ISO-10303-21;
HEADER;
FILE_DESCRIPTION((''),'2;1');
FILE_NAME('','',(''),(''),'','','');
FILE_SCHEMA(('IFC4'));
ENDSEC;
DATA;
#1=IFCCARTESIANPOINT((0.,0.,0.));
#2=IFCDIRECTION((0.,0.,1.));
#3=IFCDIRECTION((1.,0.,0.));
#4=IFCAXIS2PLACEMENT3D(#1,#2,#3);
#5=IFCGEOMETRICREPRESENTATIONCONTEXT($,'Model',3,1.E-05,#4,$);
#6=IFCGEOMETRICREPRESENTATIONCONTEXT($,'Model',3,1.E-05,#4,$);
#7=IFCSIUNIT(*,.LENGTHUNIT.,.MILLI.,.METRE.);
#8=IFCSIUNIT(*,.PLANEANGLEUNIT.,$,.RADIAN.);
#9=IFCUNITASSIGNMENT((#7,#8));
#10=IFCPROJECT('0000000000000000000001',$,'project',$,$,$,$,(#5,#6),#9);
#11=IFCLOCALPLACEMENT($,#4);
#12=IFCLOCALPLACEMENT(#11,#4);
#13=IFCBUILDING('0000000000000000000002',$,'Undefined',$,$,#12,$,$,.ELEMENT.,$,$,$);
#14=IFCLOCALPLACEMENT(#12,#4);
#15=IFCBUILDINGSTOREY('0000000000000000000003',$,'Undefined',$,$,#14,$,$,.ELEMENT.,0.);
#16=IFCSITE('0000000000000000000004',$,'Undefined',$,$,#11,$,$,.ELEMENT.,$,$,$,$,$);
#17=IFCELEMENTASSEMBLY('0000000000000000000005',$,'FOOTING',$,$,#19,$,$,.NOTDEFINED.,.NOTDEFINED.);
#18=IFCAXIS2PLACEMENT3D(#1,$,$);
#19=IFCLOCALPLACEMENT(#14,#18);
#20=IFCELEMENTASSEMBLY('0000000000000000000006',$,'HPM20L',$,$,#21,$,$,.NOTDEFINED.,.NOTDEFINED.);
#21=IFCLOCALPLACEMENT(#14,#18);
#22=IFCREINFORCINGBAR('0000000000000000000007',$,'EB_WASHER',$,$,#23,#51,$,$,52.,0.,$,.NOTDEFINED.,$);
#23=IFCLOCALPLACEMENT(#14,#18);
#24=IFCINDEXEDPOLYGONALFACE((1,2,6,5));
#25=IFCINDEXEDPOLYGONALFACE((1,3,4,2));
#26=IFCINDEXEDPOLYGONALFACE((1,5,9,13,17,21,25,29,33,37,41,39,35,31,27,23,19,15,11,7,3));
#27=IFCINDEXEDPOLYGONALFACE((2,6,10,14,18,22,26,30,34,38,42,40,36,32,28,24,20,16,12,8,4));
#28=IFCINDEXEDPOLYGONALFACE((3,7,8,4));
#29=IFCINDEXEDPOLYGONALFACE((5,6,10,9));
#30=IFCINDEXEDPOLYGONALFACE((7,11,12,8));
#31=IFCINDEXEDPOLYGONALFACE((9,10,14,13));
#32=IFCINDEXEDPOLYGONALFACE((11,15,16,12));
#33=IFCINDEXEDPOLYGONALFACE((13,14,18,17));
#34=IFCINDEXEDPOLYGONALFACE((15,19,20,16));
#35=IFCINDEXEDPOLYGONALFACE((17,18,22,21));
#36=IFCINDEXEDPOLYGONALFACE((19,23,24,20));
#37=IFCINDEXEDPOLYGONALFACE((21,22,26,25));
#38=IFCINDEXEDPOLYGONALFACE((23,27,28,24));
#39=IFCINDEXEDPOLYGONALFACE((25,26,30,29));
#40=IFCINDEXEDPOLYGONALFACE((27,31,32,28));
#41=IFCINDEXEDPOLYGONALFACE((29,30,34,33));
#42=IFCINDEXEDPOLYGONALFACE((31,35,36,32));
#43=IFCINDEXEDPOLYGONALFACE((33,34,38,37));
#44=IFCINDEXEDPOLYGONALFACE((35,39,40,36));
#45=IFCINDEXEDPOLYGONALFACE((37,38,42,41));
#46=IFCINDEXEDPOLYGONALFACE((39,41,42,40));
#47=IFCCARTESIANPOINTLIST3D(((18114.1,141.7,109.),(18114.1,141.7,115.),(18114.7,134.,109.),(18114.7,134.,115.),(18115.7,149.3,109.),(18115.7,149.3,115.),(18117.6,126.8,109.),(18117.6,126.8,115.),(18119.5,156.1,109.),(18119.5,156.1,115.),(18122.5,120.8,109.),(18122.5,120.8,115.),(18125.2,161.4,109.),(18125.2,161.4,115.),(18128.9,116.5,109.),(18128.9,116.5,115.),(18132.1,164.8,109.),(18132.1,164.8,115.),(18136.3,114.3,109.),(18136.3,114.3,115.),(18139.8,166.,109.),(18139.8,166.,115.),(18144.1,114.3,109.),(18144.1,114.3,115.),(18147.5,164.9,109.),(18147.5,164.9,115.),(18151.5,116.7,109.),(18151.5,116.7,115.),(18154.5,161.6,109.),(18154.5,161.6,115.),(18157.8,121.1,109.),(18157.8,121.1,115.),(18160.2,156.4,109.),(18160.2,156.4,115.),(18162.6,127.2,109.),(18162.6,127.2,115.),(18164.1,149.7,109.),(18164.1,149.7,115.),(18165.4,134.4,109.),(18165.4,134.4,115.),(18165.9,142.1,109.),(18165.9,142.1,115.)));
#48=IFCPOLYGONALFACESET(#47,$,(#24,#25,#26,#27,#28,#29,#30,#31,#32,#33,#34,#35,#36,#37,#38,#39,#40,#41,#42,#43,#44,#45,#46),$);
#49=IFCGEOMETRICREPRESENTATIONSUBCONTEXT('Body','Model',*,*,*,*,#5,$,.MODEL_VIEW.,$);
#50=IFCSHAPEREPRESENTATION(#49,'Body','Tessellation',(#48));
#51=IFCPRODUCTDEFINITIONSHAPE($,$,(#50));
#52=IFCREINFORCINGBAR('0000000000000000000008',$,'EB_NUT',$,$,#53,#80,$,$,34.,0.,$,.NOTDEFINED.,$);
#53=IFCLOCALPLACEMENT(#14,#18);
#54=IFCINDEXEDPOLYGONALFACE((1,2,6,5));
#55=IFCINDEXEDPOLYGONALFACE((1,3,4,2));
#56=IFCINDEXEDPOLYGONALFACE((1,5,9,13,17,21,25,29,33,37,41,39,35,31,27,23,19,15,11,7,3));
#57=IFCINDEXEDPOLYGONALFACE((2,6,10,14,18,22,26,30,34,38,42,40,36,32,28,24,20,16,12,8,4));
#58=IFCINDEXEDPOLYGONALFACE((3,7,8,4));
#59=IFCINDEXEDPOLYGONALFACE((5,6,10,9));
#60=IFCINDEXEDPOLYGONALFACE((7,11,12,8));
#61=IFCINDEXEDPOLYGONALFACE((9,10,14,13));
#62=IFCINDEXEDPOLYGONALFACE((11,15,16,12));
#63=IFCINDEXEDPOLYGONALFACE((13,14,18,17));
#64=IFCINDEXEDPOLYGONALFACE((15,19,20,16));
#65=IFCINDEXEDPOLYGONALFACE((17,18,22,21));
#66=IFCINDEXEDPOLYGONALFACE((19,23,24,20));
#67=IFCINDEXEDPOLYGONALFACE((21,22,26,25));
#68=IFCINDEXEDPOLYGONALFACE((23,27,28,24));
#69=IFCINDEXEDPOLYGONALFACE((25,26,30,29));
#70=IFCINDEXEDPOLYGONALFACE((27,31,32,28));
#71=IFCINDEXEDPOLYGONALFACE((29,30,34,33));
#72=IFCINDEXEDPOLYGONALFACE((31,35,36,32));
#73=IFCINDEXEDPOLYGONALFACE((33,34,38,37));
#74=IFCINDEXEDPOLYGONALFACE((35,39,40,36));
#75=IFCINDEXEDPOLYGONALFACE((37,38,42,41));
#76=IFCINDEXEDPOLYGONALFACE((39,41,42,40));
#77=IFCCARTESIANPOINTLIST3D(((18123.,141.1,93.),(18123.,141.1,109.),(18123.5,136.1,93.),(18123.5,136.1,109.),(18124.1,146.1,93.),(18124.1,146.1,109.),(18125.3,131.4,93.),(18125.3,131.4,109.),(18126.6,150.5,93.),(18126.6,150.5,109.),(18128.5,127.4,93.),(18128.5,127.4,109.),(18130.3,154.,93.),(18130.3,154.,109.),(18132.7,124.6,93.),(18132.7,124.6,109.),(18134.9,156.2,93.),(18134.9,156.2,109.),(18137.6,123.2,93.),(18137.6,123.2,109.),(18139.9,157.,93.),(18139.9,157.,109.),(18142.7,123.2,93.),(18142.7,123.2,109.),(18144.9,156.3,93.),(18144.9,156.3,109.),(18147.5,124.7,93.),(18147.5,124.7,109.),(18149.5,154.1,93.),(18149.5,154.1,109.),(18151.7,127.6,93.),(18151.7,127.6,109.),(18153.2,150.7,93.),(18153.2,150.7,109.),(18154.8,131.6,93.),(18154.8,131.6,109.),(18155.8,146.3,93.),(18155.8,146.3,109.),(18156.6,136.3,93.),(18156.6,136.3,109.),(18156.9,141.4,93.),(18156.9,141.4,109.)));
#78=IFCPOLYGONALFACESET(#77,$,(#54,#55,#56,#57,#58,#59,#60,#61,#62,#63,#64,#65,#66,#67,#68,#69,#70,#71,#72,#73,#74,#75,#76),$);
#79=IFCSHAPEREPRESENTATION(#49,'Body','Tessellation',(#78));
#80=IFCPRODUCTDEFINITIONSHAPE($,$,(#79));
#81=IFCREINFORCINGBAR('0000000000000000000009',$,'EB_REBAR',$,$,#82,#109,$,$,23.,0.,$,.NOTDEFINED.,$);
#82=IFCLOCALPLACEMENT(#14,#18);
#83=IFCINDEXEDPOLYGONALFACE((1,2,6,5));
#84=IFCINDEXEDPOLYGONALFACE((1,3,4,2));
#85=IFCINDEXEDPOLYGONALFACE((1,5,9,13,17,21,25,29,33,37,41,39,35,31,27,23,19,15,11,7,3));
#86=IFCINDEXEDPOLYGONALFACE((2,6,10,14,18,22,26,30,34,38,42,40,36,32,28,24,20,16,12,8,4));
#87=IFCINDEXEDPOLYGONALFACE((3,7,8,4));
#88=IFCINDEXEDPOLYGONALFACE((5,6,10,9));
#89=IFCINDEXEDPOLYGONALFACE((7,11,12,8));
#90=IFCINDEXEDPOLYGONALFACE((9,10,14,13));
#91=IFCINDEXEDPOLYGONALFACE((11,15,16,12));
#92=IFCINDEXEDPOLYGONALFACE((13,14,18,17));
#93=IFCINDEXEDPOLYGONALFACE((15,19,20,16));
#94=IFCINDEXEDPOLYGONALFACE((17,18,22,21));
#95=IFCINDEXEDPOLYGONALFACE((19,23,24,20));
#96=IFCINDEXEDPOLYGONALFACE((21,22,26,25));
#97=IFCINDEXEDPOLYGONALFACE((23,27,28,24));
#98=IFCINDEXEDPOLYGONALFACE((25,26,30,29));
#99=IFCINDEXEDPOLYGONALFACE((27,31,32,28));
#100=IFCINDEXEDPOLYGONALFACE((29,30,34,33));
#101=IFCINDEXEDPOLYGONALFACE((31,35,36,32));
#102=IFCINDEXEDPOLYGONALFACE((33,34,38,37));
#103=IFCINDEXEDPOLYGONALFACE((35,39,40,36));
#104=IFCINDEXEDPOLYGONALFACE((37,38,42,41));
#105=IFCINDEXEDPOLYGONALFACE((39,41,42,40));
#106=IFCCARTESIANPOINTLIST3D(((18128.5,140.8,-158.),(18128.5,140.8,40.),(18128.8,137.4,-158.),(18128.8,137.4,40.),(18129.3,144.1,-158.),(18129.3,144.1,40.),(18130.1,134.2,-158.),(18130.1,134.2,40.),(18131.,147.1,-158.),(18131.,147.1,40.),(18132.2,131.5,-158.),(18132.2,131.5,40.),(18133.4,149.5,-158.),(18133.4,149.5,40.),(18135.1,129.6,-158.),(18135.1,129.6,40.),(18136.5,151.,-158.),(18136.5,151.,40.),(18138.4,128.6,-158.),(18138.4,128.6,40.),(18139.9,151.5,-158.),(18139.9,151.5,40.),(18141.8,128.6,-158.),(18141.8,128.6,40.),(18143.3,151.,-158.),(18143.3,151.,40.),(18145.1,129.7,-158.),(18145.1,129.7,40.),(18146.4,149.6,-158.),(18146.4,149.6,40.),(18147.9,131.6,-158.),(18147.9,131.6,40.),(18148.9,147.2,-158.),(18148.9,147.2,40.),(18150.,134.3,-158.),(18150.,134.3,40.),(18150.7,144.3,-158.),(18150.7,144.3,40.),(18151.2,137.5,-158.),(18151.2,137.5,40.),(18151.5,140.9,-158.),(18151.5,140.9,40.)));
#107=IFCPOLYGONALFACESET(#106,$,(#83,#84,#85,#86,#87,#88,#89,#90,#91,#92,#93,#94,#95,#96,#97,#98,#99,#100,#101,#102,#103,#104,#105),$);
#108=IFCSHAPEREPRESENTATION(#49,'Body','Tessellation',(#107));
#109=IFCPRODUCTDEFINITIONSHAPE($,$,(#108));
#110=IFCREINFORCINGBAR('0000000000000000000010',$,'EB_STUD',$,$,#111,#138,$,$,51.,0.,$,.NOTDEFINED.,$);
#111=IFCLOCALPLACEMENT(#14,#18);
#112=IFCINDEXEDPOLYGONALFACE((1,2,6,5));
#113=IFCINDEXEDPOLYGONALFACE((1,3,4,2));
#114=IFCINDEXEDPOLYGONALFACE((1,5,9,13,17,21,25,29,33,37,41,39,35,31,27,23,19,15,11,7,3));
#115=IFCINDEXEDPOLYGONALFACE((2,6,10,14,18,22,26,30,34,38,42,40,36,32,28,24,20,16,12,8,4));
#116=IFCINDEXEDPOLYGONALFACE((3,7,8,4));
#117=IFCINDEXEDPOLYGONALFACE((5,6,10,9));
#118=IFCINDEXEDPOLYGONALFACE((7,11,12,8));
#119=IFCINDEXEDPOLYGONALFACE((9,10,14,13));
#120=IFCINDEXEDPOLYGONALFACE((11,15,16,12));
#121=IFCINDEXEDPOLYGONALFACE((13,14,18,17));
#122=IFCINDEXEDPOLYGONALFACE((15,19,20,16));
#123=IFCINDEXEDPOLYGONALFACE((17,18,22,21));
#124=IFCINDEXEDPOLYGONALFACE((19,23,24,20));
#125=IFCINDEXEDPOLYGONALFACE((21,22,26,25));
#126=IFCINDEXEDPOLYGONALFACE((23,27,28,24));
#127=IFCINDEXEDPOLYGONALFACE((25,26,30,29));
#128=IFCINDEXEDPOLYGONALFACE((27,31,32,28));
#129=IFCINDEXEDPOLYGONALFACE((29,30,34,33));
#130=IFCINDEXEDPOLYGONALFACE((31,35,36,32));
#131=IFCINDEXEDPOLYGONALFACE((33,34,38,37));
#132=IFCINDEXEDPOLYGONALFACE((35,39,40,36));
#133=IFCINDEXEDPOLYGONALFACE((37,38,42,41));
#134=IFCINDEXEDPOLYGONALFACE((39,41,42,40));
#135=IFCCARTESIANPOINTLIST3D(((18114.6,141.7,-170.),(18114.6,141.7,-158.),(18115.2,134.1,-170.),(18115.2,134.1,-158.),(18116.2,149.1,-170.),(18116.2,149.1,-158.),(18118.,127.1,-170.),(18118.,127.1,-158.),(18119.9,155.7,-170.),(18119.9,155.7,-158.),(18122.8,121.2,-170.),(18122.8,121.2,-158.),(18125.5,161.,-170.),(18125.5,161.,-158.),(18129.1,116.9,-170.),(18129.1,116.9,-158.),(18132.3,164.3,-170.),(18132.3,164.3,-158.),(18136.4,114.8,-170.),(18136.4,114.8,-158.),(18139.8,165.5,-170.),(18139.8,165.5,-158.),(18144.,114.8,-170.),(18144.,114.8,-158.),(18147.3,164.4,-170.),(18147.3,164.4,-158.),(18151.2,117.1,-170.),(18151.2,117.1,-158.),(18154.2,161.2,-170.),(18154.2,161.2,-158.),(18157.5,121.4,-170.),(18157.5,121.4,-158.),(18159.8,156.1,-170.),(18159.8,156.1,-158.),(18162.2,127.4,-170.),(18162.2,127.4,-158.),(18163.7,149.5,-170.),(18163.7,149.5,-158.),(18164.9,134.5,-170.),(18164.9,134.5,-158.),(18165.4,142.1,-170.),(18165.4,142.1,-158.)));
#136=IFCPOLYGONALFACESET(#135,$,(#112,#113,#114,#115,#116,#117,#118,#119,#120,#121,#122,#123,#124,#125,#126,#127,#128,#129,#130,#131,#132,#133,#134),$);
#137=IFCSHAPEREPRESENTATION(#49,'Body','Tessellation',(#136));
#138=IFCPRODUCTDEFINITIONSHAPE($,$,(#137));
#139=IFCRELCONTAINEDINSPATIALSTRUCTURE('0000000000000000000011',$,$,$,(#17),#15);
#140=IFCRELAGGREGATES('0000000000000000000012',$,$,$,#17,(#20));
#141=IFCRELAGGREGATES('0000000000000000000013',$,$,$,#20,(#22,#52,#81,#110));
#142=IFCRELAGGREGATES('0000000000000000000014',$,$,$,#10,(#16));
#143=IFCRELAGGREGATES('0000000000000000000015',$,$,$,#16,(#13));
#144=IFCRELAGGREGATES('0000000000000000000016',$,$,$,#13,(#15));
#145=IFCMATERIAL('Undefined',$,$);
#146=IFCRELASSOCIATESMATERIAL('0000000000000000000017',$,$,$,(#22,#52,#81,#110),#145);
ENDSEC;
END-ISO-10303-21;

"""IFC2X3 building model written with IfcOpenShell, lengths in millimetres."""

from ifc_helpers import new_model, entity, si_unit, frame, origin_with_axes, place, context, subcontext, project, spatial, source, transform, mapped, material, element, aggregate, save


model = new_model("IFC2X3")

# Units and contexts
model_context_1 = context("Model", 3, precision=1e-05, world=origin_with_axes())
model_context_2 = context("Model", 3, precision=1e-05, world=origin_with_axes())
body_context = subcontext(model_context_1, "Body", "Model", "MODEL_VIEW")
ifc_project = project(units=[si_unit("LENGTHUNIT", "METRE", prefix="MILLI"), si_unit("PLANEANGLEUNIT", "RADIAN")], contexts=[model_context_1, model_context_2])

# Site, building, storey
site_placement = place(None, origin_with_axes())
site = spatial("IfcSite", under=ifc_project, at=site_placement, Name="Undefined", CompositionType="ELEMENT")
building_placement = place(site_placement, origin_with_axes())
building = spatial("IfcBuilding", under=site, at=building_placement, Name="Undefined", CompositionType="ELEMENT")
storey_placement = place(building_placement, origin_with_axes())
storey = spatial("IfcBuildingStorey", under=building, at=storey_placement, Name="Undefined", CompositionType="ELEMENT", Elevation=0.0)

# Element assembly
assembly_1_placement = place(storey_placement, origin_with_axes())
assembly_1 = element("IfcElementAssembly", 1, at=assembly_1_placement, inside=storey, Name="FOOTING", AssemblyPlace="NOTDEFINED", PredefinedType="NOTDEFINED")

# Shared definitions
ifc_material_1 = material(Name="Undefined")

# Element assembly
assembly_2_placement = place(assembly_1_placement, origin_with_axes())
assembly_2 = element("IfcElementAssembly", 2, at=assembly_2_placement, Name="HPM20L", AssemblyPlace="NOTDEFINED", PredefinedType="NOTDEFINED")
aggregate(assembly_1, [assembly_2])

# Reinforcing bars
shared_shape_1 = source(origin_with_axes(), body_context, "Body", "AdvancedSweptSolid", [
    entity("IfcSweptDiskSolid", entity("IfcTrimmedCurve", entity("IfcLine", entity("IfcCartesianPoint", [0.0, 0.0, 0.0]), entity("IfcVector", entity("IfcDirection", [1.0, 0.0, 0.0]), 1.0)), [entity("IfcParameterValue", 0.0)], [entity("IfcParameterValue", 6.0)], True, "PARAMETER"), 26.0, None, 0.0, 6.0),
])
reinforcing_bar_1_placement = place(assembly_2_placement, frame((18140.0, 140.0, 115.0), z_axis=(-0.007718, 0.99997, 0.0), x_axis=(0.0, 0.0, -1.0)))
reinforcing_bar_1 = element("IfcReinforcingBar", 3, at=reinforcing_bar_1_placement, material=ifc_material_1, Name="EB_WASHER", BarRole="NOTDEFINED", CrossSectionArea=0.0, NominalDiameter=52.0, context=body_context, shape_type="MappedRepresentation", body=[
    mapped(shared_shape_1, transform((0.0, 0.0, 0.0))),
])
shared_shape_2 = source(origin_with_axes(), body_context, "Body", "AdvancedSweptSolid", [
    entity("IfcSweptDiskSolid", entity("IfcTrimmedCurve", entity("IfcLine", entity("IfcCartesianPoint", [0.0, 0.0, 0.0]), entity("IfcVector", entity("IfcDirection", [1.0, 0.0, 0.0]), 1.0)), [entity("IfcParameterValue", 0.0)], [entity("IfcParameterValue", 16.0)], True, "PARAMETER"), 17.0, None, 0.0, 16.0),
])
reinforcing_bar_2_placement = place(assembly_2_placement, frame((18140.0, 140.0, 109.0), z_axis=(-0.007718, 0.99997, 0.0), x_axis=(0.0, 0.0, -1.0)))
reinforcing_bar_2 = element("IfcReinforcingBar", 4, at=reinforcing_bar_2_placement, material=ifc_material_1, Name="EB_NUT", BarRole="NOTDEFINED", CrossSectionArea=0.0, NominalDiameter=34.0, context=body_context, shape_type="MappedRepresentation", body=[
    mapped(shared_shape_2, transform((0.0, 0.0, 0.0))),
])
shared_shape_3 = source(origin_with_axes(), body_context, "Body", "AdvancedSweptSolid", [
    entity("IfcSweptDiskSolid", entity("IfcTrimmedCurve", entity("IfcLine", entity("IfcCartesianPoint", [0.0, 0.0, 0.0]), entity("IfcVector", entity("IfcDirection", [1.0, 0.0, 0.0]), 1.0)), [entity("IfcParameterValue", 0.0)], [entity("IfcParameterValue", 198.0)], True, "PARAMETER"), 11.5, None, 0.0, 198.0),
])
reinforcing_bar_3_placement = place(assembly_2_placement, frame((18140.0, 140.0, 40.0), z_axis=(-0.007718, 0.99997, 0.0), x_axis=(0.0, 0.0, -1.0)))
reinforcing_bar_3 = element("IfcReinforcingBar", 5, at=reinforcing_bar_3_placement, material=ifc_material_1, Name="EB_REBAR", BarRole="NOTDEFINED", CrossSectionArea=0.0, NominalDiameter=23.0, context=body_context, shape_type="MappedRepresentation", body=[
    mapped(shared_shape_3, transform((0.0, 0.0, 0.0))),
])
shared_shape_4 = source(origin_with_axes(), body_context, "Body", "AdvancedSweptSolid", [
    entity("IfcSweptDiskSolid", entity("IfcTrimmedCurve", entity("IfcLine", entity("IfcCartesianPoint", [0.0, 0.0, 0.0]), entity("IfcVector", entity("IfcDirection", [1.0, 0.0, 0.0]), 1.0)), [entity("IfcParameterValue", 0.0)], [entity("IfcParameterValue", 12.0)], True, "PARAMETER"), 25.5, None, 0.0, 12.0),
])
reinforcing_bar_4_placement = place(assembly_2_placement, frame((18140.0, 140.0, -158.0), z_axis=(-0.007718, 0.99997, 0.0), x_axis=(0.0, 0.0, -1.0)))
reinforcing_bar_4 = element("IfcReinforcingBar", 6, at=reinforcing_bar_4_placement, material=ifc_material_1, Name="EB_STUD", BarRole="NOTDEFINED", CrossSectionArea=0.0, NominalDiameter=51.0, context=body_context, shape_type="MappedRepresentation", body=[
    mapped(shared_shape_4, transform((0.0, 0.0, 0.0))),
])
aggregate(assembly_2, [reinforcing_bar_1, reinforcing_bar_2, reinforcing_bar_3, reinforcing_bar_4])

save(model, "model.ifc")
